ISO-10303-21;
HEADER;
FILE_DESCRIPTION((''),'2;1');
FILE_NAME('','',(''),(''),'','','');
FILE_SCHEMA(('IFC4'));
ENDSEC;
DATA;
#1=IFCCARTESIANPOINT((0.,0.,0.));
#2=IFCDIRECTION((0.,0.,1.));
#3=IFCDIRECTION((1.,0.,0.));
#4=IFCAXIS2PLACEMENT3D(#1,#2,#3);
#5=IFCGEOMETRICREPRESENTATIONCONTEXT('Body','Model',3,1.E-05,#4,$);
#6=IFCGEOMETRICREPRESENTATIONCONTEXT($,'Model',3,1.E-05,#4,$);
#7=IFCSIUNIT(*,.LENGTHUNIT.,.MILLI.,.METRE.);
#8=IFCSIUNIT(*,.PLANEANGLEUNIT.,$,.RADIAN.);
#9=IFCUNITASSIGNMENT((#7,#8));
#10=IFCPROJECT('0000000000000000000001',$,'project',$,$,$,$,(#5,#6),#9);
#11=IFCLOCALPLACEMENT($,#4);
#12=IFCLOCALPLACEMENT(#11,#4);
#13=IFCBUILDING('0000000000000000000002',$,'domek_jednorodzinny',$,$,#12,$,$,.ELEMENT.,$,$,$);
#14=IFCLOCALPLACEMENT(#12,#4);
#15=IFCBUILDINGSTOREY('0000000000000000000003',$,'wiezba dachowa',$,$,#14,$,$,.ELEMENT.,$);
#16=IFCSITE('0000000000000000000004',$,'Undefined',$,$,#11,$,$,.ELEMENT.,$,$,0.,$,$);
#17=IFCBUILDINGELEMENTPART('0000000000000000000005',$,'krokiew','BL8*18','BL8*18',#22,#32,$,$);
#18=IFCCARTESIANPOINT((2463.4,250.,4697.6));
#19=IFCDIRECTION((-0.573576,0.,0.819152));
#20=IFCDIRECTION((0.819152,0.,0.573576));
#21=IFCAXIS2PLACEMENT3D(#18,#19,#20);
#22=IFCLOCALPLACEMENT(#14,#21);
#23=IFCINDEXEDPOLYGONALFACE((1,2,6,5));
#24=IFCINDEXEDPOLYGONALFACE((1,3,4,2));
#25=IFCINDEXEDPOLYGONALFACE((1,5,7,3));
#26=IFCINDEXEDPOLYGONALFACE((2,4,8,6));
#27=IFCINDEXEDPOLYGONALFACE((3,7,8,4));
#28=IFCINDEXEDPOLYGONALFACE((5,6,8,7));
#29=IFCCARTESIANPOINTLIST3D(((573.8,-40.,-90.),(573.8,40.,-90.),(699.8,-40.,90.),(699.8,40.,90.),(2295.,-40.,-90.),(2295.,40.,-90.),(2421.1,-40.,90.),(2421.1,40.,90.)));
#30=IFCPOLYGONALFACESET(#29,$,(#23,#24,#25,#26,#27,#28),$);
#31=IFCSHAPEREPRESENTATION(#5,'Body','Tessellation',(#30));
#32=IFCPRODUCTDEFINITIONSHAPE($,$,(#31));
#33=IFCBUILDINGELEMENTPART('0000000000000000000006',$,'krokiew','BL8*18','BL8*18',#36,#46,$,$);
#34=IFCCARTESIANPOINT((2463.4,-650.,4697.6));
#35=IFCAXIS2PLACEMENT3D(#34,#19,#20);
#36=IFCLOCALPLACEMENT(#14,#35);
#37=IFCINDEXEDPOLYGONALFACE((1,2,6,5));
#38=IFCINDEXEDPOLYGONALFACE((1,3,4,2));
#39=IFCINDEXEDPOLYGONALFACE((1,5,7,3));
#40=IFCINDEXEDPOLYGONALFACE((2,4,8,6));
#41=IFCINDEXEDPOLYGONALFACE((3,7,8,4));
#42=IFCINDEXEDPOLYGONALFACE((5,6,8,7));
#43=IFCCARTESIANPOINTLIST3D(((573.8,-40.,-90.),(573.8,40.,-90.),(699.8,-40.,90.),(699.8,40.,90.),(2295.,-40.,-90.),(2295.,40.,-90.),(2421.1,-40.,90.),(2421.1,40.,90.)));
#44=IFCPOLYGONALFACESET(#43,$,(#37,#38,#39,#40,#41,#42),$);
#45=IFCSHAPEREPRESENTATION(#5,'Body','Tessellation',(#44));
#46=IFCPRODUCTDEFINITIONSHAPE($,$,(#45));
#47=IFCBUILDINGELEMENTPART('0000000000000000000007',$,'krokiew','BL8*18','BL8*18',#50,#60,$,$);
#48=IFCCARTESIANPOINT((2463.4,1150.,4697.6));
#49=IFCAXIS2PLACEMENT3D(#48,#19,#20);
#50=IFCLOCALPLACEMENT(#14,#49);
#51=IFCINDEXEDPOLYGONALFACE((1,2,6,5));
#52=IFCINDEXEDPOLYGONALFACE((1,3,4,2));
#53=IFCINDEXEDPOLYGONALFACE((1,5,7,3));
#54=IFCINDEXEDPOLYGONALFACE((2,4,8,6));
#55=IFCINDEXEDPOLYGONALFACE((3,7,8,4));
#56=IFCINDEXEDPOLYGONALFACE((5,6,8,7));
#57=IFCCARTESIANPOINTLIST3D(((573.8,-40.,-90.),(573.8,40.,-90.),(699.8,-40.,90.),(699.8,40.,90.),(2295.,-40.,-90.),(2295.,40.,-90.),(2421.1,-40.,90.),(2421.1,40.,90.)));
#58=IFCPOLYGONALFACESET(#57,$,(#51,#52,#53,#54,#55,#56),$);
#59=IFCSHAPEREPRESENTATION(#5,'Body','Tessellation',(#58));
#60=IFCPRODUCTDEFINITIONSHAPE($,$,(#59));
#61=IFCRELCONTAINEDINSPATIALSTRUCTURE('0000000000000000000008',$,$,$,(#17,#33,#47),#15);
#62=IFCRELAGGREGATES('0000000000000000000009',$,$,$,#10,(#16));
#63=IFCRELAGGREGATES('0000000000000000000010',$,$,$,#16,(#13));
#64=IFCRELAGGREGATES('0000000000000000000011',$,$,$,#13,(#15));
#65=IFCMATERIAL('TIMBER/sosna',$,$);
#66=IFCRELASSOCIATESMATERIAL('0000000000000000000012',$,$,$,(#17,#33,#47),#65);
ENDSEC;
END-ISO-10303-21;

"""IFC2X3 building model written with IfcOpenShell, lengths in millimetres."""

from ifc_helpers import new_model, si_unit, frame, origin_with_axes, origin_2d_with_axis, place, context, project, spatial, rectangle, extrude, clip, halfspace, material, element, save


model = new_model("IFC2X3")

# Units and contexts
model_context_1 = context("Model", 3, precision=1e-05, world=origin_with_axes(), identifier="Body")
model_context_2 = context("Model", 3, precision=1e-05, world=origin_with_axes())
ifc_project = project(units=[si_unit("LENGTHUNIT", "METRE", prefix="MILLI"), si_unit("PLANEANGLEUNIT", "RADIAN")], contexts=[model_context_1, model_context_2])

# Site, building, storey
site_placement = place(None, origin_with_axes())
site = spatial("IfcSite", under=ifc_project, at=site_placement, Name="Undefined", CompositionType="ELEMENT", RefElevation=0.0)
building_placement = place(site_placement, origin_with_axes())
building = spatial("IfcBuilding", under=site, at=building_placement, Name="domek_jednorodzinny", CompositionType="ELEMENT")
storey_placement = place(building_placement, origin_with_axes())
storey = spatial("IfcBuildingStorey", under=building, at=storey_placement, Name="wiezba dachowa", CompositionType="ELEMENT")

# Building element parts
ifc_material = material(Name="TIMBER/sosna")
for number, where, z_axis, x_axis, name in (
    (1, (2463.4, 250.0, 4697.6), (-0.573576, 0.0, 0.819152), (0.819152, 0.0, 0.573576), "krokiew"),
    (2, (2463.4, -650.0, 4697.6), (-0.573576, 0.0, 0.819152), (0.819152, 0.0, 0.573576), "krokiew"),
    (3, (2463.4, 1150.0, 4697.6), (-0.573576, 0.0, 0.819152), (0.819152, 0.0, 0.573576), "krokiew"),
):
    element("IfcBuildingElementPart", number, at=place(storey_placement, frame(where, z_axis=z_axis, x_axis=x_axis)), inside=storey, material=ifc_material, Name=name, Description="BL8*18", ObjectType="BL8*18", context=model_context_1, shape_type="Clipping", body=[
        clip(clip(extrude(rectangle(XDim=80.0, YDim=180.0, at=origin_2d_with_axis()), frame((2421.1, 0.0, 0.0), z_axis=(-1.0, 0.0, 0.0), x_axis=(0.0, -1.0, 0.0)), (0.0, 0.0, 1.0), 2421.1), halfspace(frame((2295.0, -40.0, -90.0), z_axis=(0.819151, 0.0, -0.573578), x_axis=(0.573578, 0.0, 0.819151)), False)), halfspace(frame((385.0, 40.0, -359.6), z_axis=(-0.819152, 0.0, 0.573576), x_axis=(0.573578, 0.0, 0.819151)), False)),
    ])

save(model, "model.ifc")
